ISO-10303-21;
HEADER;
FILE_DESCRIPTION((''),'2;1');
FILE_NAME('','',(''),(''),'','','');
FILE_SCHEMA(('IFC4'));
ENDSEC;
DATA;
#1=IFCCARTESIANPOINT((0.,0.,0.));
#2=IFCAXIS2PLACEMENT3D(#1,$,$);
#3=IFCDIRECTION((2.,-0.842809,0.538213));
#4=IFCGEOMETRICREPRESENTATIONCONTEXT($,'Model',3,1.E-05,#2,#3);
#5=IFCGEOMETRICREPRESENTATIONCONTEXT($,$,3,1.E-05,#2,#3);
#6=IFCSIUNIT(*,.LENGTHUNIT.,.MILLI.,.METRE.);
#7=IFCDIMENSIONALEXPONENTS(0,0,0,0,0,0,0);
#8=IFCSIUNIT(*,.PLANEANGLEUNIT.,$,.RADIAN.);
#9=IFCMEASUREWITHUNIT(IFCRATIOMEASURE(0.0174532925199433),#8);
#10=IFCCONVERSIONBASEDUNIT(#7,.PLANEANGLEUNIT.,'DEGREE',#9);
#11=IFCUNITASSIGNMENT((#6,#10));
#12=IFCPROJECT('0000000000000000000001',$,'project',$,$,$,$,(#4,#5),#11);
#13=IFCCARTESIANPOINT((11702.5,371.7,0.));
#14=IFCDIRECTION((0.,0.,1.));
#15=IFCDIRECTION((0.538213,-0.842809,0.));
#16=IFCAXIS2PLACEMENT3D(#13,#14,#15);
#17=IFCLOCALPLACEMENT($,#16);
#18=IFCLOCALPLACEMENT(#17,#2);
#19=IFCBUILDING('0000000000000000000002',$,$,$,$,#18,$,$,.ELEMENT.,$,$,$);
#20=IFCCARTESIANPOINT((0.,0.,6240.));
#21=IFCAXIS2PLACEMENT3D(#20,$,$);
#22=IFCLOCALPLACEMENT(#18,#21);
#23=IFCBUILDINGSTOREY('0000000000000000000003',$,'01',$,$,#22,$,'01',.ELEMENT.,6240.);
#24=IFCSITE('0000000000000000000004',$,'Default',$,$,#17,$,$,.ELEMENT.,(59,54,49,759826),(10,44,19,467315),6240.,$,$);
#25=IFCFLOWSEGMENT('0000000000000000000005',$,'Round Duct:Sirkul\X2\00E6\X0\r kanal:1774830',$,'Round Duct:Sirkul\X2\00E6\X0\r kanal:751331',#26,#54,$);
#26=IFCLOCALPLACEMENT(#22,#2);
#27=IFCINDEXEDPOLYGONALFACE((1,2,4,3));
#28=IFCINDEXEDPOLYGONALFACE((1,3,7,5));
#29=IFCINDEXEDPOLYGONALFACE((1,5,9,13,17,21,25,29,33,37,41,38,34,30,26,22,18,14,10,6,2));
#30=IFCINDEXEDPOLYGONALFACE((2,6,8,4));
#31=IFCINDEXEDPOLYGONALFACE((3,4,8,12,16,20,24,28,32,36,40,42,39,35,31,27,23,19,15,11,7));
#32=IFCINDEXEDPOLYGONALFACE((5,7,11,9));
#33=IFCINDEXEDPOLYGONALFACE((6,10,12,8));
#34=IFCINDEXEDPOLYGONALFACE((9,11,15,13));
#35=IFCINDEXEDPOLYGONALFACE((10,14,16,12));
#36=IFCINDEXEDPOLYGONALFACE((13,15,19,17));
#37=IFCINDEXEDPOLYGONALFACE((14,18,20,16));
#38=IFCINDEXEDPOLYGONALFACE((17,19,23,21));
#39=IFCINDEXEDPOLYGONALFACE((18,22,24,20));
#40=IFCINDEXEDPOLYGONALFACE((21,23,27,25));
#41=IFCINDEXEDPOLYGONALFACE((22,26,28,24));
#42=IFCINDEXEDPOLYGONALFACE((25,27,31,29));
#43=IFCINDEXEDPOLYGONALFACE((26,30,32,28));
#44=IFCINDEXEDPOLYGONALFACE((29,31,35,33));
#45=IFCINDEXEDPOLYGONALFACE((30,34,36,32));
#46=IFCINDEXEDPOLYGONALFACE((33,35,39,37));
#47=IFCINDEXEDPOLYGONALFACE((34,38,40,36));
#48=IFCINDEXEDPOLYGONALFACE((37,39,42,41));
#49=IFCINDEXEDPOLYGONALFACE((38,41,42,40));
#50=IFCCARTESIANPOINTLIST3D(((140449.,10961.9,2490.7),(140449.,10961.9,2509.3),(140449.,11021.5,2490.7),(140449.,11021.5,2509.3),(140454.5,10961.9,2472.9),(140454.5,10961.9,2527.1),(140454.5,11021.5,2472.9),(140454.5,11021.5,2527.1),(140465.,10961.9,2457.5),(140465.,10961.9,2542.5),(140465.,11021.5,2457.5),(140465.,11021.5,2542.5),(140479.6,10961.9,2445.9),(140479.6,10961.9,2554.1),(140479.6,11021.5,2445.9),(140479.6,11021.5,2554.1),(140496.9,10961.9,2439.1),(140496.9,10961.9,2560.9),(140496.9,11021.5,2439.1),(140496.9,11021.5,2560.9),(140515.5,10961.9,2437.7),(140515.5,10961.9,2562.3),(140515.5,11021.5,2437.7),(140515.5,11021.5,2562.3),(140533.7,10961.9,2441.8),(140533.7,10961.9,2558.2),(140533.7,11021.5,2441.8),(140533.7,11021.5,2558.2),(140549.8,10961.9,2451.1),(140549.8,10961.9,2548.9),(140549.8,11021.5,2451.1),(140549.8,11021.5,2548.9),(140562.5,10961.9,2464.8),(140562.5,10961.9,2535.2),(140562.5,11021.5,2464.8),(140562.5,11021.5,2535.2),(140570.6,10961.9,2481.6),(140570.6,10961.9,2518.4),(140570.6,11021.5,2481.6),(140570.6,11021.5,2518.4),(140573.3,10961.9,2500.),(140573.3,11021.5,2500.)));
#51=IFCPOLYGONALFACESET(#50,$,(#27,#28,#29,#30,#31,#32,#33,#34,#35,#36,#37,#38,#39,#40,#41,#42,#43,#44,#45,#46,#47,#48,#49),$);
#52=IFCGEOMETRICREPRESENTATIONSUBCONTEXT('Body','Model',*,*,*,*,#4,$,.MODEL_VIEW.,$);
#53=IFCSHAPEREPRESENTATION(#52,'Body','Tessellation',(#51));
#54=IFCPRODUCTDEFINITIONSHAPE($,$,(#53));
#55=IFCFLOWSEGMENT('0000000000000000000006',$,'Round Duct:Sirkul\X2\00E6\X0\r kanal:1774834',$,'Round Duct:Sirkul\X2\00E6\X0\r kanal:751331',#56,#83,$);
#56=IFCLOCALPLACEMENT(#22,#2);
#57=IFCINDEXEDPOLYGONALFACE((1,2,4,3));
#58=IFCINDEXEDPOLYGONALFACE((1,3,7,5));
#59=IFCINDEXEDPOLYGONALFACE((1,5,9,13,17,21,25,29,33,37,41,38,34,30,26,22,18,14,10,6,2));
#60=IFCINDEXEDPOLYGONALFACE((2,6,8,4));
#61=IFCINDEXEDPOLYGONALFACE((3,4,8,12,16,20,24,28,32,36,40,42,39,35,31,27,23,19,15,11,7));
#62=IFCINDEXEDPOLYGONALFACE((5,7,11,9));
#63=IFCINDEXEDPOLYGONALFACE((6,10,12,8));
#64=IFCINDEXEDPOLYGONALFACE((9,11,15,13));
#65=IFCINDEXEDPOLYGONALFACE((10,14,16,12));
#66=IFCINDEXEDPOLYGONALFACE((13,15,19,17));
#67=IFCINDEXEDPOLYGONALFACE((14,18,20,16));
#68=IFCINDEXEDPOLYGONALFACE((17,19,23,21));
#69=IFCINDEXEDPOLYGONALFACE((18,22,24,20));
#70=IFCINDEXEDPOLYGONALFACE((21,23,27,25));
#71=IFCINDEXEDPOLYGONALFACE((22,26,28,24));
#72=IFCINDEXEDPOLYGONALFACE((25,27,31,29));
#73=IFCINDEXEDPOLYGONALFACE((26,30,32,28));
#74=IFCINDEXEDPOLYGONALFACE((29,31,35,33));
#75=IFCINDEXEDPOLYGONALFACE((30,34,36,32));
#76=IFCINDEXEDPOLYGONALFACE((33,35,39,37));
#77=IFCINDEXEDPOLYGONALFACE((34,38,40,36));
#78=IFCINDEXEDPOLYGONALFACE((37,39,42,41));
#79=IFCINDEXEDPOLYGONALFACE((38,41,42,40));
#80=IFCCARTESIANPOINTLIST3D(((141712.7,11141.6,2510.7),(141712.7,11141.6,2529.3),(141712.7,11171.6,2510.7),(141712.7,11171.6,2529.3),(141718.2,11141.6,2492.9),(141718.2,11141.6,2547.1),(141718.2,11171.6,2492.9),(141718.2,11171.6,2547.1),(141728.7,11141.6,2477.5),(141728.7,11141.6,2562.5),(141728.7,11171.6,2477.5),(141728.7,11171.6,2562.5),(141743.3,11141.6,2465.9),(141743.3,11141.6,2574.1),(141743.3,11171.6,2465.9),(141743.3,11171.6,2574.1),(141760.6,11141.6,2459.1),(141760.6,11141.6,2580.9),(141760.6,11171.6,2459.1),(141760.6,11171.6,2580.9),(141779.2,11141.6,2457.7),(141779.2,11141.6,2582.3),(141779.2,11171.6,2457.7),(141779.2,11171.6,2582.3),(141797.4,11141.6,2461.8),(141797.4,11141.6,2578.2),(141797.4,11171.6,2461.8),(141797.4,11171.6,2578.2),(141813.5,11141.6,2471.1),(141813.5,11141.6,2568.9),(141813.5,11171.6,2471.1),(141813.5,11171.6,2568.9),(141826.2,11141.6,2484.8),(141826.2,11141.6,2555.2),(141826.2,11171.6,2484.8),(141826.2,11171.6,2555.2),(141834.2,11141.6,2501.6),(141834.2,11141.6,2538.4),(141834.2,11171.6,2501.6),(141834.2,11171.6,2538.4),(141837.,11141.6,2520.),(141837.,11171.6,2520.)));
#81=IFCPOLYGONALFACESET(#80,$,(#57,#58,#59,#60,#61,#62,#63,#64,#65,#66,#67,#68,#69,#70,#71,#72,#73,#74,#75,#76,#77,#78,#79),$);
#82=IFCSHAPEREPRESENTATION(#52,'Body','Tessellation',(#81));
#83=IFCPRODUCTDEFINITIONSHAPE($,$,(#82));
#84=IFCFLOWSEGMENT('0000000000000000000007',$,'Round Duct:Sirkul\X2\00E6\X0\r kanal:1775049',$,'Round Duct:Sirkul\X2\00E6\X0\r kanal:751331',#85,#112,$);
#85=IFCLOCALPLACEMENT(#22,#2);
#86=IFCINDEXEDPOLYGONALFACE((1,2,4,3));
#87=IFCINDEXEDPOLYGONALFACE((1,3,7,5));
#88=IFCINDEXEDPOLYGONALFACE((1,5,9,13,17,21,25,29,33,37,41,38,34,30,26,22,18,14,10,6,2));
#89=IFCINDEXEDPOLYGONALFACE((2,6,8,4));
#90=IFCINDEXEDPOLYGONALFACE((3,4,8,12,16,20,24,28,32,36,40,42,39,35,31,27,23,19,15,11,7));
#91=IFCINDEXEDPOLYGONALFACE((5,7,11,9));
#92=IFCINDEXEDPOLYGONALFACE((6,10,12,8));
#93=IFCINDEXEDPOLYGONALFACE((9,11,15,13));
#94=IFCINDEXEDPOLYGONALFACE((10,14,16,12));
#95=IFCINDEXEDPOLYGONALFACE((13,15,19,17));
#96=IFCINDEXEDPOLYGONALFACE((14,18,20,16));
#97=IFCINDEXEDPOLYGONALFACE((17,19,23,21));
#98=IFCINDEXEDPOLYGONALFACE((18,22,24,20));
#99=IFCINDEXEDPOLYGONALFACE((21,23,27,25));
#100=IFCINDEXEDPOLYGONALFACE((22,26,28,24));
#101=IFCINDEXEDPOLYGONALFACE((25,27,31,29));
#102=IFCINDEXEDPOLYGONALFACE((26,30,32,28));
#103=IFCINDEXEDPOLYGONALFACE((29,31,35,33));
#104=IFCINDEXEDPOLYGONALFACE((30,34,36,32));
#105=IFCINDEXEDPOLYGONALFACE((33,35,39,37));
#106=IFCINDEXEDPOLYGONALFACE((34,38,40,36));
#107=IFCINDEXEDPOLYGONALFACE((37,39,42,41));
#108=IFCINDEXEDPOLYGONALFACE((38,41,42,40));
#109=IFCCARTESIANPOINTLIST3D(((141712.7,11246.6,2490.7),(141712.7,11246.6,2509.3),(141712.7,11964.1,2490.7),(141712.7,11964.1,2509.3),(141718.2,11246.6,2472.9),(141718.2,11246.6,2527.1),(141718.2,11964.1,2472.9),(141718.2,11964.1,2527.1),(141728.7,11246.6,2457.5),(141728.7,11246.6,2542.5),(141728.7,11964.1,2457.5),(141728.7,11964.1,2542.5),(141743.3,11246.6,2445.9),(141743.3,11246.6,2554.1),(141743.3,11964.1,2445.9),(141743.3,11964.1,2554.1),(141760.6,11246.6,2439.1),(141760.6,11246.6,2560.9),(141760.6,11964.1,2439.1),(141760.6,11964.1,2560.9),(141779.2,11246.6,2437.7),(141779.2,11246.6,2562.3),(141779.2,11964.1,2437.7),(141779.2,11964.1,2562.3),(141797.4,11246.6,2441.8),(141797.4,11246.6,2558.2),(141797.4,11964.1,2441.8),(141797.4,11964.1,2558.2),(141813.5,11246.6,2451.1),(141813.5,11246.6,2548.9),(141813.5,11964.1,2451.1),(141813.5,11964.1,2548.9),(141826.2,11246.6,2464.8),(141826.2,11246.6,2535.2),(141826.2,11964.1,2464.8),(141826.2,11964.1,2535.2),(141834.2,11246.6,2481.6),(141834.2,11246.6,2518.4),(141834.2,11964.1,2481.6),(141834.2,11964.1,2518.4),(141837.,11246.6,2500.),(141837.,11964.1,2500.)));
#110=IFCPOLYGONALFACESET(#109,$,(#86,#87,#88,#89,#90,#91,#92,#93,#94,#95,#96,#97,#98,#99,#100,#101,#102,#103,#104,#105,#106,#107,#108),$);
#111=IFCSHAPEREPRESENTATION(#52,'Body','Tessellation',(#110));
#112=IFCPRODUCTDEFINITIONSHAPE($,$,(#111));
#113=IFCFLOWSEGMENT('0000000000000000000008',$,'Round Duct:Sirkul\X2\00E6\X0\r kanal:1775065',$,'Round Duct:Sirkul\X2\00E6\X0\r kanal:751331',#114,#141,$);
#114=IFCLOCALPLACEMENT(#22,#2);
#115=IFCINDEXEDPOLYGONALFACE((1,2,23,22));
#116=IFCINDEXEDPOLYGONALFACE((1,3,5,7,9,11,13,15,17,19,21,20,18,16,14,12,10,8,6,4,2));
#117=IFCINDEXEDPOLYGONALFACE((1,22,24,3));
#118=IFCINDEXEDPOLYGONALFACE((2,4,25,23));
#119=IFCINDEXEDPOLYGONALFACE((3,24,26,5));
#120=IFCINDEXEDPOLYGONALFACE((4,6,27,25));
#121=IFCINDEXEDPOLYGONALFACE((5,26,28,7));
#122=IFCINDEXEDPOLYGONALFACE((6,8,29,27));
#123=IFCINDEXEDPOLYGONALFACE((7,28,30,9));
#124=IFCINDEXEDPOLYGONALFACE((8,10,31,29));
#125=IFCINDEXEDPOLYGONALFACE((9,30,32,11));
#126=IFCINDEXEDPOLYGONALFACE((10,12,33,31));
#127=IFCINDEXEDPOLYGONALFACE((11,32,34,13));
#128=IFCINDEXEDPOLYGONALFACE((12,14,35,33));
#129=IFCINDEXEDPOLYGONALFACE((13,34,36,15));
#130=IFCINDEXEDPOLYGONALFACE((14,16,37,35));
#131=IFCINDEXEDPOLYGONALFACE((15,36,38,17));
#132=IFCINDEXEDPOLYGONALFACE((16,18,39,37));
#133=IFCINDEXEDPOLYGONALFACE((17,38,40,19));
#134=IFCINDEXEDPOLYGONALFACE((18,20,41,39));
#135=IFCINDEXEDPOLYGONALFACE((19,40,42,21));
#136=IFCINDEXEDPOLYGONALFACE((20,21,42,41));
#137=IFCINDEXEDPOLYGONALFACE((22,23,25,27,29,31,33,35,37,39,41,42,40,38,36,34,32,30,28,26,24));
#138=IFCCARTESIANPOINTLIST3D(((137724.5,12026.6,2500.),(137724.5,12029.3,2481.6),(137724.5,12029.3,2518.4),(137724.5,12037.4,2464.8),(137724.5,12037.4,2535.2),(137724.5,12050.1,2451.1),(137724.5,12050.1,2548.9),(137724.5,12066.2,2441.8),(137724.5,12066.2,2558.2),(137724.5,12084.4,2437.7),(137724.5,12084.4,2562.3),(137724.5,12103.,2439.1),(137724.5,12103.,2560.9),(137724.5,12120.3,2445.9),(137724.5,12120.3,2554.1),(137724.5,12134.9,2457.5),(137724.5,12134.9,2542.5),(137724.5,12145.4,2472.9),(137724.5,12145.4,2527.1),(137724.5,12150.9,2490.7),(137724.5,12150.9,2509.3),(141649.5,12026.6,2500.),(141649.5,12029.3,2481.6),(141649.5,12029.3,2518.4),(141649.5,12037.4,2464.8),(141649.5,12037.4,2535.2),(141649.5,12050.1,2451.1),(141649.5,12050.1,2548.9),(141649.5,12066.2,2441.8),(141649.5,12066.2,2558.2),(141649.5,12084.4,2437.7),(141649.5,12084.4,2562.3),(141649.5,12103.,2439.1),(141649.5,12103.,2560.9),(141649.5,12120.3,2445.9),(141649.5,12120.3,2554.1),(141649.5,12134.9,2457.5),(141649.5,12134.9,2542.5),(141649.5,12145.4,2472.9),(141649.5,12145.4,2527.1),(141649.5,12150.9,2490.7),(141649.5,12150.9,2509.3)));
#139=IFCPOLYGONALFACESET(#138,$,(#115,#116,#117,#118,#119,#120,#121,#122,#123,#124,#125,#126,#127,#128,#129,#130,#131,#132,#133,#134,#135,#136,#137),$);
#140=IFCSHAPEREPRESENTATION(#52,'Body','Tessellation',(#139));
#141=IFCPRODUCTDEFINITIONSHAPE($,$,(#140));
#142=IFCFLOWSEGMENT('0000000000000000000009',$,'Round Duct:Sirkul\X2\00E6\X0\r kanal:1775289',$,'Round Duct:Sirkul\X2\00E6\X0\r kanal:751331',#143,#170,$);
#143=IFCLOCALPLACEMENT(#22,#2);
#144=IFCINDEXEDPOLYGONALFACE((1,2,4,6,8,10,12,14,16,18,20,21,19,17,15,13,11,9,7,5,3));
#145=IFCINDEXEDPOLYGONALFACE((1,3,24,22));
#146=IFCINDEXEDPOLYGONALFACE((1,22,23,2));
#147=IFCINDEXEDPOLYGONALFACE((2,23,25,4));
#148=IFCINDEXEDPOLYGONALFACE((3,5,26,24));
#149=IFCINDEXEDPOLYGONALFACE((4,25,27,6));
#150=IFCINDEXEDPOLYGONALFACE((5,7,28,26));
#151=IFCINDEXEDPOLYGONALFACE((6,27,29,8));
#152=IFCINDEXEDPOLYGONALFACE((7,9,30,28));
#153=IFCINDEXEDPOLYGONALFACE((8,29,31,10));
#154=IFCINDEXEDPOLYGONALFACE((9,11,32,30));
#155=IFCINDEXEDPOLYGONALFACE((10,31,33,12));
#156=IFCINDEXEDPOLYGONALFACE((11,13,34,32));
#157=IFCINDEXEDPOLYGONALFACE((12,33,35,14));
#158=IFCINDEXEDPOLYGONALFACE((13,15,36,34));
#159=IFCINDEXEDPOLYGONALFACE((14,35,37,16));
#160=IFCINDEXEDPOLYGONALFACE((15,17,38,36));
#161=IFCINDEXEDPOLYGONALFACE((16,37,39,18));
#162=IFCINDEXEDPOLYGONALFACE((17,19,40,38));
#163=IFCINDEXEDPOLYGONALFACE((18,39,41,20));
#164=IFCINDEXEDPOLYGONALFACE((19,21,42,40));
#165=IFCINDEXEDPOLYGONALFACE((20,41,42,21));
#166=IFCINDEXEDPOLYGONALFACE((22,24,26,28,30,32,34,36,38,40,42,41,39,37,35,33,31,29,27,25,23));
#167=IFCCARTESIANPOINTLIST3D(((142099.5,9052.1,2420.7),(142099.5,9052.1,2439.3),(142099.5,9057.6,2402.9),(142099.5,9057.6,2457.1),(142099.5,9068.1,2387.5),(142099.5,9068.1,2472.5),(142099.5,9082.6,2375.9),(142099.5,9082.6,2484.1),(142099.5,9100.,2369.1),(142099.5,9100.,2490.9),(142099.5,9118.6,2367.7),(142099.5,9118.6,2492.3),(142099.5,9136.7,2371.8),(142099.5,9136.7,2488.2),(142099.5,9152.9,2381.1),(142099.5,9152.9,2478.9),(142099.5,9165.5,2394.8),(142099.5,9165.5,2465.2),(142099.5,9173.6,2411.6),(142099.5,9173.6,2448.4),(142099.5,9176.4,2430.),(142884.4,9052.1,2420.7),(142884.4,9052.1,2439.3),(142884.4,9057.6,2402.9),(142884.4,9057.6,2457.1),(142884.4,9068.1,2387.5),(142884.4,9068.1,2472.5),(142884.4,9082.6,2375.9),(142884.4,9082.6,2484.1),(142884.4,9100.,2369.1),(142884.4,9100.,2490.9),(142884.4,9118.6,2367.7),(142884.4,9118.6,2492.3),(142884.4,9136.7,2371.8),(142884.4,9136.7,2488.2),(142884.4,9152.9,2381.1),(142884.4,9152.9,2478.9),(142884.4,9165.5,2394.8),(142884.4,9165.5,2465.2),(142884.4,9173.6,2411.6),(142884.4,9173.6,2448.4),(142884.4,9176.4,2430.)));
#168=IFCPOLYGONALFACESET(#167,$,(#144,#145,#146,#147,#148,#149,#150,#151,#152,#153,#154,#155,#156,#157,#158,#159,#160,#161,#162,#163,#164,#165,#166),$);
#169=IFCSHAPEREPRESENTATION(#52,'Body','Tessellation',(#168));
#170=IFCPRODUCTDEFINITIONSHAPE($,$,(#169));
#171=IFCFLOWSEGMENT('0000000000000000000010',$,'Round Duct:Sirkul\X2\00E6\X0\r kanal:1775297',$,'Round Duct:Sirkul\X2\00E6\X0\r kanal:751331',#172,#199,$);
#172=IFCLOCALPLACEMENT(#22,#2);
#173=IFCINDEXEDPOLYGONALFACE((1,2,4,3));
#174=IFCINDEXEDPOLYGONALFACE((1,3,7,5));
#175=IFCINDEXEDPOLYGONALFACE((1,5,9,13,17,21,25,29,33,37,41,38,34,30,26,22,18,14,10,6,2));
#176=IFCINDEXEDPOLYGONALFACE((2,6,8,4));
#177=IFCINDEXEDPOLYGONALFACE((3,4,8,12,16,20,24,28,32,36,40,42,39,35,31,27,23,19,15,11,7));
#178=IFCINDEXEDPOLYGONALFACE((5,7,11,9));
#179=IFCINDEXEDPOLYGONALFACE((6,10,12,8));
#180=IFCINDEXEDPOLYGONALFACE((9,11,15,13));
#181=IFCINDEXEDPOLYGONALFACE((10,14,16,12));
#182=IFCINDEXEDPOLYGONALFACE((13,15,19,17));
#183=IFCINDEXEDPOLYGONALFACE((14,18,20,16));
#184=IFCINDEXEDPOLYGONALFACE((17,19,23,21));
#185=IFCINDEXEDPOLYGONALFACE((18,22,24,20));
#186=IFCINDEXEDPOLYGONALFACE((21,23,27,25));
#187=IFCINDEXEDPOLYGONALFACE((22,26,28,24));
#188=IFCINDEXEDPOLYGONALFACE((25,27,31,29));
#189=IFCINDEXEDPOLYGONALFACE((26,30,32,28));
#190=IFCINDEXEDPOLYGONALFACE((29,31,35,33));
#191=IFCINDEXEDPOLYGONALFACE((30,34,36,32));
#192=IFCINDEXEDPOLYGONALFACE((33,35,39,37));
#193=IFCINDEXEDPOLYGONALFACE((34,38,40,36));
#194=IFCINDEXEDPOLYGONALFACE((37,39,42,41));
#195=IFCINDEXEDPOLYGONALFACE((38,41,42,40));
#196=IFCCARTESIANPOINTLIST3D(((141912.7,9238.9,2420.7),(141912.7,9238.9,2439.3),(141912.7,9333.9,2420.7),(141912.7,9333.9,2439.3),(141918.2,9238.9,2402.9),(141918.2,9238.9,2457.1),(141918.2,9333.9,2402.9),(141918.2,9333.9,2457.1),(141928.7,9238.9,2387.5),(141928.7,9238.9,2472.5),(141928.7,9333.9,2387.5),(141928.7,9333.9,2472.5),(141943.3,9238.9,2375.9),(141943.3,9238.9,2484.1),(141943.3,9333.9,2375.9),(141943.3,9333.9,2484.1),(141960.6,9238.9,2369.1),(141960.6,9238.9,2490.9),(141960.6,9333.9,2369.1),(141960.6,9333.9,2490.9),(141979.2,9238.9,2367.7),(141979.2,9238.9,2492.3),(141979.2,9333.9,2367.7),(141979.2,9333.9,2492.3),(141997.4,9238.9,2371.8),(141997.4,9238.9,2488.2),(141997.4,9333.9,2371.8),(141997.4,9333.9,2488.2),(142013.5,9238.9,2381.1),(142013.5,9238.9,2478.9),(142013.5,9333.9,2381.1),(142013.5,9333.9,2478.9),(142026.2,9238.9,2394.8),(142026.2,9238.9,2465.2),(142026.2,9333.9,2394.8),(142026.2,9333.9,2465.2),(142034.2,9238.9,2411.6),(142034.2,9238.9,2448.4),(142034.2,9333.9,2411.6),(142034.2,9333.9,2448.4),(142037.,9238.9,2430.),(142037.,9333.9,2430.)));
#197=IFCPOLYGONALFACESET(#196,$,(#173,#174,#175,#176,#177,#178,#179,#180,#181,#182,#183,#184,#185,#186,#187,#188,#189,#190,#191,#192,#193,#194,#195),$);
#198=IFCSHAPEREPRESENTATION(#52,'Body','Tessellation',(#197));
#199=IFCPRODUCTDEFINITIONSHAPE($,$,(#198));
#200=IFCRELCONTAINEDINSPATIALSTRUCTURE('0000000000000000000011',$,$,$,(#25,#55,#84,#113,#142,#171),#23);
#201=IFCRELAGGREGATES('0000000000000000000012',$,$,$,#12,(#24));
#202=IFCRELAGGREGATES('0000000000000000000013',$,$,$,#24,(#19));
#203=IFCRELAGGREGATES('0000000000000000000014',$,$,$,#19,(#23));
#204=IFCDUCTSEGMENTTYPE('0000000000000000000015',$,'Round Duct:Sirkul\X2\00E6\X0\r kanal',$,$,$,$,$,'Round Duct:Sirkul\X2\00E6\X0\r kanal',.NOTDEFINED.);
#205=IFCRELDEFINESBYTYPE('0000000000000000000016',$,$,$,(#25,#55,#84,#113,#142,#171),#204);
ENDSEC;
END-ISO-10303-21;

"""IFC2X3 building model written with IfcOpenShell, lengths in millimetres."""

from ifc_helpers import new_model, entity, si_unit, converted_unit, direction, frame, frame_2d, origin, origin_2d_with_axis, place, context, subcontext, project, spatial, circle, extrude, type_object, element, save


model = new_model("IFC2X3")

# Units and contexts
model_context = context("Model", 3, precision=1e-05, world=origin(), true_north=direction((2.0, -0.842809, 0.538213)))
context_of_model = context(None, 3, precision=1e-05, world=origin(), true_north=direction((2.0, -0.842809, 0.538213)))
body_context = subcontext(model_context, "Body", "Model", "MODEL_VIEW")
ifc_project = project(units=[si_unit("LENGTHUNIT", "METRE", prefix="MILLI"), converted_unit("PLANEANGLEUNIT", "DEGREE", entity("IfcRatioMeasure", 0.0174532925199433), si_unit("PLANEANGLEUNIT", "RADIAN"), dimensions=[0, 0, 0, 0, 0, 0, 0])], contexts=[model_context, context_of_model])

# Site, building, storey
site_placement = place(None, frame((11702.5, 371.7, 0.0), z_axis=(0.0, 0.0, 1.0), x_axis=(0.538213, -0.842809, 0.0)))
site = spatial("IfcSite", under=ifc_project, at=site_placement, Name="Default", CompositionType="ELEMENT", RefLatitude=(59, 54, 49, 759826), RefLongitude=(10, 44, 19, 467315), RefElevation=6240.0)
building_placement = place(site_placement, origin())
building = spatial("IfcBuilding", under=site, at=building_placement, CompositionType="ELEMENT")
storey_placement = place(building_placement, frame((0.0, 0.0, 6240.0)))
storey = spatial("IfcBuildingStorey", under=building, at=storey_placement, Name="01", LongName="01", CompositionType="ELEMENT", Elevation=6240.0)

# Flow segments
duct_segment_type_1 = type_object("IfcDuctSegmentType", Name="Round Duct:Sirkulær kanal", ElementType="Round Duct:Sirkulær kanal", PredefinedType="NOTDEFINED")
flow_segment_1_placement = place(storey_placement, origin())
element("IfcFlowSegment", 1, at=flow_segment_1_placement, inside=storey, type_object=duct_segment_type_1, Name="Round Duct:Sirkulær kanal:1774830", ObjectType="Round Duct:Sirkulær kanal:751331", context=body_context, shape_type="SweptSolid", body=[
    extrude(circle(Radius=62.5, at=frame_2d((0.0, 0.0), x_axis=(1.0, 0.0))), frame((140510.8, 10961.9, 2500.0), z_axis=(0.0, 1.0, 0.0), x_axis=(1.0, 0.0, 0.0)), (0.0, 0.0, 1.0), 59.6),
])
flow_segment_2_placement = place(storey_placement, origin())
element("IfcFlowSegment", 2, at=flow_segment_2_placement, inside=storey, type_object=duct_segment_type_1, Name="Round Duct:Sirkulær kanal:1774834", ObjectType="Round Duct:Sirkulær kanal:751331", context=body_context, shape_type="SweptSolid", body=[
    extrude(circle(Radius=62.5, at=frame_2d((0.0, 0.0), x_axis=(1.0, 0.0))), frame((141774.5, 11141.6, 2520.0), z_axis=(0.0, 1.0, 0.0), x_axis=(1.0, 0.0, 0.0)), (0.0, 0.0, 1.0), 30.0),
])
flow_segment_3_placement = place(storey_placement, origin())
element("IfcFlowSegment", 3, at=flow_segment_3_placement, inside=storey, type_object=duct_segment_type_1, Name="Round Duct:Sirkulær kanal:1775049", ObjectType="Round Duct:Sirkulær kanal:751331", context=body_context, shape_type="SweptSolid", body=[
    extrude(circle(Radius=62.5, at=frame_2d((0.0, 0.0), x_axis=(1.0, 0.0))), frame((141774.5, 11246.6, 2500.0), z_axis=(0.0, 1.0, 0.0), x_axis=(1.0, 0.0, 0.0)), (0.0, 0.0, 1.0), 717.5),
])
flow_segment_4_placement = place(storey_placement, origin())
element("IfcFlowSegment", 4, at=flow_segment_4_placement, inside=storey, type_object=duct_segment_type_1, Name="Round Duct:Sirkulær kanal:1775065", ObjectType="Round Duct:Sirkulær kanal:751331", context=body_context, shape_type="SweptSolid", body=[
    extrude(circle(Radius=62.5, at=frame_2d((0.0, 0.0), x_axis=(1.0, 0.0))), frame((137724.5, 12089.1, 2500.0), z_axis=(1.0, 0.0, 0.0), x_axis=(0.0, -1.0, 0.0)), (0.0, 0.0, 1.0), 3925.0),
])
flow_segment_5_placement = place(storey_placement, origin())
element("IfcFlowSegment", 5, at=flow_segment_5_placement, inside=storey, type_object=duct_segment_type_1, Name="Round Duct:Sirkulær kanal:1775289", ObjectType="Round Duct:Sirkulær kanal:751331", context=body_context, shape_type="SweptSolid", body=[
    extrude(circle(Radius=62.5, at=frame_2d((0.0, 0.0), x_axis=(1.0, 0.0))), frame((142099.5, 9113.9, 2430.0), z_axis=(1.0, 0.0, 0.0), x_axis=(0.0, 1.0, 0.0)), (0.0, 0.0, 1.0), 784.9),
])
flow_segment_6_placement = place(storey_placement, origin())
element("IfcFlowSegment", 6, at=flow_segment_6_placement, inside=storey, type_object=duct_segment_type_1, Name="Round Duct:Sirkulær kanal:1775297", ObjectType="Round Duct:Sirkulær kanal:751331", context=body_context, shape_type="SweptSolid", body=[
    extrude(circle(Radius=62.5, at=origin_2d_with_axis()), frame((141974.5, 9238.9, 2430.0), z_axis=(0.0, 1.0, 0.0), x_axis=(1.0, 0.0, 0.0)), (0.0, 0.0, 1.0), 95.0),
])

save(model, "model.ifc")
